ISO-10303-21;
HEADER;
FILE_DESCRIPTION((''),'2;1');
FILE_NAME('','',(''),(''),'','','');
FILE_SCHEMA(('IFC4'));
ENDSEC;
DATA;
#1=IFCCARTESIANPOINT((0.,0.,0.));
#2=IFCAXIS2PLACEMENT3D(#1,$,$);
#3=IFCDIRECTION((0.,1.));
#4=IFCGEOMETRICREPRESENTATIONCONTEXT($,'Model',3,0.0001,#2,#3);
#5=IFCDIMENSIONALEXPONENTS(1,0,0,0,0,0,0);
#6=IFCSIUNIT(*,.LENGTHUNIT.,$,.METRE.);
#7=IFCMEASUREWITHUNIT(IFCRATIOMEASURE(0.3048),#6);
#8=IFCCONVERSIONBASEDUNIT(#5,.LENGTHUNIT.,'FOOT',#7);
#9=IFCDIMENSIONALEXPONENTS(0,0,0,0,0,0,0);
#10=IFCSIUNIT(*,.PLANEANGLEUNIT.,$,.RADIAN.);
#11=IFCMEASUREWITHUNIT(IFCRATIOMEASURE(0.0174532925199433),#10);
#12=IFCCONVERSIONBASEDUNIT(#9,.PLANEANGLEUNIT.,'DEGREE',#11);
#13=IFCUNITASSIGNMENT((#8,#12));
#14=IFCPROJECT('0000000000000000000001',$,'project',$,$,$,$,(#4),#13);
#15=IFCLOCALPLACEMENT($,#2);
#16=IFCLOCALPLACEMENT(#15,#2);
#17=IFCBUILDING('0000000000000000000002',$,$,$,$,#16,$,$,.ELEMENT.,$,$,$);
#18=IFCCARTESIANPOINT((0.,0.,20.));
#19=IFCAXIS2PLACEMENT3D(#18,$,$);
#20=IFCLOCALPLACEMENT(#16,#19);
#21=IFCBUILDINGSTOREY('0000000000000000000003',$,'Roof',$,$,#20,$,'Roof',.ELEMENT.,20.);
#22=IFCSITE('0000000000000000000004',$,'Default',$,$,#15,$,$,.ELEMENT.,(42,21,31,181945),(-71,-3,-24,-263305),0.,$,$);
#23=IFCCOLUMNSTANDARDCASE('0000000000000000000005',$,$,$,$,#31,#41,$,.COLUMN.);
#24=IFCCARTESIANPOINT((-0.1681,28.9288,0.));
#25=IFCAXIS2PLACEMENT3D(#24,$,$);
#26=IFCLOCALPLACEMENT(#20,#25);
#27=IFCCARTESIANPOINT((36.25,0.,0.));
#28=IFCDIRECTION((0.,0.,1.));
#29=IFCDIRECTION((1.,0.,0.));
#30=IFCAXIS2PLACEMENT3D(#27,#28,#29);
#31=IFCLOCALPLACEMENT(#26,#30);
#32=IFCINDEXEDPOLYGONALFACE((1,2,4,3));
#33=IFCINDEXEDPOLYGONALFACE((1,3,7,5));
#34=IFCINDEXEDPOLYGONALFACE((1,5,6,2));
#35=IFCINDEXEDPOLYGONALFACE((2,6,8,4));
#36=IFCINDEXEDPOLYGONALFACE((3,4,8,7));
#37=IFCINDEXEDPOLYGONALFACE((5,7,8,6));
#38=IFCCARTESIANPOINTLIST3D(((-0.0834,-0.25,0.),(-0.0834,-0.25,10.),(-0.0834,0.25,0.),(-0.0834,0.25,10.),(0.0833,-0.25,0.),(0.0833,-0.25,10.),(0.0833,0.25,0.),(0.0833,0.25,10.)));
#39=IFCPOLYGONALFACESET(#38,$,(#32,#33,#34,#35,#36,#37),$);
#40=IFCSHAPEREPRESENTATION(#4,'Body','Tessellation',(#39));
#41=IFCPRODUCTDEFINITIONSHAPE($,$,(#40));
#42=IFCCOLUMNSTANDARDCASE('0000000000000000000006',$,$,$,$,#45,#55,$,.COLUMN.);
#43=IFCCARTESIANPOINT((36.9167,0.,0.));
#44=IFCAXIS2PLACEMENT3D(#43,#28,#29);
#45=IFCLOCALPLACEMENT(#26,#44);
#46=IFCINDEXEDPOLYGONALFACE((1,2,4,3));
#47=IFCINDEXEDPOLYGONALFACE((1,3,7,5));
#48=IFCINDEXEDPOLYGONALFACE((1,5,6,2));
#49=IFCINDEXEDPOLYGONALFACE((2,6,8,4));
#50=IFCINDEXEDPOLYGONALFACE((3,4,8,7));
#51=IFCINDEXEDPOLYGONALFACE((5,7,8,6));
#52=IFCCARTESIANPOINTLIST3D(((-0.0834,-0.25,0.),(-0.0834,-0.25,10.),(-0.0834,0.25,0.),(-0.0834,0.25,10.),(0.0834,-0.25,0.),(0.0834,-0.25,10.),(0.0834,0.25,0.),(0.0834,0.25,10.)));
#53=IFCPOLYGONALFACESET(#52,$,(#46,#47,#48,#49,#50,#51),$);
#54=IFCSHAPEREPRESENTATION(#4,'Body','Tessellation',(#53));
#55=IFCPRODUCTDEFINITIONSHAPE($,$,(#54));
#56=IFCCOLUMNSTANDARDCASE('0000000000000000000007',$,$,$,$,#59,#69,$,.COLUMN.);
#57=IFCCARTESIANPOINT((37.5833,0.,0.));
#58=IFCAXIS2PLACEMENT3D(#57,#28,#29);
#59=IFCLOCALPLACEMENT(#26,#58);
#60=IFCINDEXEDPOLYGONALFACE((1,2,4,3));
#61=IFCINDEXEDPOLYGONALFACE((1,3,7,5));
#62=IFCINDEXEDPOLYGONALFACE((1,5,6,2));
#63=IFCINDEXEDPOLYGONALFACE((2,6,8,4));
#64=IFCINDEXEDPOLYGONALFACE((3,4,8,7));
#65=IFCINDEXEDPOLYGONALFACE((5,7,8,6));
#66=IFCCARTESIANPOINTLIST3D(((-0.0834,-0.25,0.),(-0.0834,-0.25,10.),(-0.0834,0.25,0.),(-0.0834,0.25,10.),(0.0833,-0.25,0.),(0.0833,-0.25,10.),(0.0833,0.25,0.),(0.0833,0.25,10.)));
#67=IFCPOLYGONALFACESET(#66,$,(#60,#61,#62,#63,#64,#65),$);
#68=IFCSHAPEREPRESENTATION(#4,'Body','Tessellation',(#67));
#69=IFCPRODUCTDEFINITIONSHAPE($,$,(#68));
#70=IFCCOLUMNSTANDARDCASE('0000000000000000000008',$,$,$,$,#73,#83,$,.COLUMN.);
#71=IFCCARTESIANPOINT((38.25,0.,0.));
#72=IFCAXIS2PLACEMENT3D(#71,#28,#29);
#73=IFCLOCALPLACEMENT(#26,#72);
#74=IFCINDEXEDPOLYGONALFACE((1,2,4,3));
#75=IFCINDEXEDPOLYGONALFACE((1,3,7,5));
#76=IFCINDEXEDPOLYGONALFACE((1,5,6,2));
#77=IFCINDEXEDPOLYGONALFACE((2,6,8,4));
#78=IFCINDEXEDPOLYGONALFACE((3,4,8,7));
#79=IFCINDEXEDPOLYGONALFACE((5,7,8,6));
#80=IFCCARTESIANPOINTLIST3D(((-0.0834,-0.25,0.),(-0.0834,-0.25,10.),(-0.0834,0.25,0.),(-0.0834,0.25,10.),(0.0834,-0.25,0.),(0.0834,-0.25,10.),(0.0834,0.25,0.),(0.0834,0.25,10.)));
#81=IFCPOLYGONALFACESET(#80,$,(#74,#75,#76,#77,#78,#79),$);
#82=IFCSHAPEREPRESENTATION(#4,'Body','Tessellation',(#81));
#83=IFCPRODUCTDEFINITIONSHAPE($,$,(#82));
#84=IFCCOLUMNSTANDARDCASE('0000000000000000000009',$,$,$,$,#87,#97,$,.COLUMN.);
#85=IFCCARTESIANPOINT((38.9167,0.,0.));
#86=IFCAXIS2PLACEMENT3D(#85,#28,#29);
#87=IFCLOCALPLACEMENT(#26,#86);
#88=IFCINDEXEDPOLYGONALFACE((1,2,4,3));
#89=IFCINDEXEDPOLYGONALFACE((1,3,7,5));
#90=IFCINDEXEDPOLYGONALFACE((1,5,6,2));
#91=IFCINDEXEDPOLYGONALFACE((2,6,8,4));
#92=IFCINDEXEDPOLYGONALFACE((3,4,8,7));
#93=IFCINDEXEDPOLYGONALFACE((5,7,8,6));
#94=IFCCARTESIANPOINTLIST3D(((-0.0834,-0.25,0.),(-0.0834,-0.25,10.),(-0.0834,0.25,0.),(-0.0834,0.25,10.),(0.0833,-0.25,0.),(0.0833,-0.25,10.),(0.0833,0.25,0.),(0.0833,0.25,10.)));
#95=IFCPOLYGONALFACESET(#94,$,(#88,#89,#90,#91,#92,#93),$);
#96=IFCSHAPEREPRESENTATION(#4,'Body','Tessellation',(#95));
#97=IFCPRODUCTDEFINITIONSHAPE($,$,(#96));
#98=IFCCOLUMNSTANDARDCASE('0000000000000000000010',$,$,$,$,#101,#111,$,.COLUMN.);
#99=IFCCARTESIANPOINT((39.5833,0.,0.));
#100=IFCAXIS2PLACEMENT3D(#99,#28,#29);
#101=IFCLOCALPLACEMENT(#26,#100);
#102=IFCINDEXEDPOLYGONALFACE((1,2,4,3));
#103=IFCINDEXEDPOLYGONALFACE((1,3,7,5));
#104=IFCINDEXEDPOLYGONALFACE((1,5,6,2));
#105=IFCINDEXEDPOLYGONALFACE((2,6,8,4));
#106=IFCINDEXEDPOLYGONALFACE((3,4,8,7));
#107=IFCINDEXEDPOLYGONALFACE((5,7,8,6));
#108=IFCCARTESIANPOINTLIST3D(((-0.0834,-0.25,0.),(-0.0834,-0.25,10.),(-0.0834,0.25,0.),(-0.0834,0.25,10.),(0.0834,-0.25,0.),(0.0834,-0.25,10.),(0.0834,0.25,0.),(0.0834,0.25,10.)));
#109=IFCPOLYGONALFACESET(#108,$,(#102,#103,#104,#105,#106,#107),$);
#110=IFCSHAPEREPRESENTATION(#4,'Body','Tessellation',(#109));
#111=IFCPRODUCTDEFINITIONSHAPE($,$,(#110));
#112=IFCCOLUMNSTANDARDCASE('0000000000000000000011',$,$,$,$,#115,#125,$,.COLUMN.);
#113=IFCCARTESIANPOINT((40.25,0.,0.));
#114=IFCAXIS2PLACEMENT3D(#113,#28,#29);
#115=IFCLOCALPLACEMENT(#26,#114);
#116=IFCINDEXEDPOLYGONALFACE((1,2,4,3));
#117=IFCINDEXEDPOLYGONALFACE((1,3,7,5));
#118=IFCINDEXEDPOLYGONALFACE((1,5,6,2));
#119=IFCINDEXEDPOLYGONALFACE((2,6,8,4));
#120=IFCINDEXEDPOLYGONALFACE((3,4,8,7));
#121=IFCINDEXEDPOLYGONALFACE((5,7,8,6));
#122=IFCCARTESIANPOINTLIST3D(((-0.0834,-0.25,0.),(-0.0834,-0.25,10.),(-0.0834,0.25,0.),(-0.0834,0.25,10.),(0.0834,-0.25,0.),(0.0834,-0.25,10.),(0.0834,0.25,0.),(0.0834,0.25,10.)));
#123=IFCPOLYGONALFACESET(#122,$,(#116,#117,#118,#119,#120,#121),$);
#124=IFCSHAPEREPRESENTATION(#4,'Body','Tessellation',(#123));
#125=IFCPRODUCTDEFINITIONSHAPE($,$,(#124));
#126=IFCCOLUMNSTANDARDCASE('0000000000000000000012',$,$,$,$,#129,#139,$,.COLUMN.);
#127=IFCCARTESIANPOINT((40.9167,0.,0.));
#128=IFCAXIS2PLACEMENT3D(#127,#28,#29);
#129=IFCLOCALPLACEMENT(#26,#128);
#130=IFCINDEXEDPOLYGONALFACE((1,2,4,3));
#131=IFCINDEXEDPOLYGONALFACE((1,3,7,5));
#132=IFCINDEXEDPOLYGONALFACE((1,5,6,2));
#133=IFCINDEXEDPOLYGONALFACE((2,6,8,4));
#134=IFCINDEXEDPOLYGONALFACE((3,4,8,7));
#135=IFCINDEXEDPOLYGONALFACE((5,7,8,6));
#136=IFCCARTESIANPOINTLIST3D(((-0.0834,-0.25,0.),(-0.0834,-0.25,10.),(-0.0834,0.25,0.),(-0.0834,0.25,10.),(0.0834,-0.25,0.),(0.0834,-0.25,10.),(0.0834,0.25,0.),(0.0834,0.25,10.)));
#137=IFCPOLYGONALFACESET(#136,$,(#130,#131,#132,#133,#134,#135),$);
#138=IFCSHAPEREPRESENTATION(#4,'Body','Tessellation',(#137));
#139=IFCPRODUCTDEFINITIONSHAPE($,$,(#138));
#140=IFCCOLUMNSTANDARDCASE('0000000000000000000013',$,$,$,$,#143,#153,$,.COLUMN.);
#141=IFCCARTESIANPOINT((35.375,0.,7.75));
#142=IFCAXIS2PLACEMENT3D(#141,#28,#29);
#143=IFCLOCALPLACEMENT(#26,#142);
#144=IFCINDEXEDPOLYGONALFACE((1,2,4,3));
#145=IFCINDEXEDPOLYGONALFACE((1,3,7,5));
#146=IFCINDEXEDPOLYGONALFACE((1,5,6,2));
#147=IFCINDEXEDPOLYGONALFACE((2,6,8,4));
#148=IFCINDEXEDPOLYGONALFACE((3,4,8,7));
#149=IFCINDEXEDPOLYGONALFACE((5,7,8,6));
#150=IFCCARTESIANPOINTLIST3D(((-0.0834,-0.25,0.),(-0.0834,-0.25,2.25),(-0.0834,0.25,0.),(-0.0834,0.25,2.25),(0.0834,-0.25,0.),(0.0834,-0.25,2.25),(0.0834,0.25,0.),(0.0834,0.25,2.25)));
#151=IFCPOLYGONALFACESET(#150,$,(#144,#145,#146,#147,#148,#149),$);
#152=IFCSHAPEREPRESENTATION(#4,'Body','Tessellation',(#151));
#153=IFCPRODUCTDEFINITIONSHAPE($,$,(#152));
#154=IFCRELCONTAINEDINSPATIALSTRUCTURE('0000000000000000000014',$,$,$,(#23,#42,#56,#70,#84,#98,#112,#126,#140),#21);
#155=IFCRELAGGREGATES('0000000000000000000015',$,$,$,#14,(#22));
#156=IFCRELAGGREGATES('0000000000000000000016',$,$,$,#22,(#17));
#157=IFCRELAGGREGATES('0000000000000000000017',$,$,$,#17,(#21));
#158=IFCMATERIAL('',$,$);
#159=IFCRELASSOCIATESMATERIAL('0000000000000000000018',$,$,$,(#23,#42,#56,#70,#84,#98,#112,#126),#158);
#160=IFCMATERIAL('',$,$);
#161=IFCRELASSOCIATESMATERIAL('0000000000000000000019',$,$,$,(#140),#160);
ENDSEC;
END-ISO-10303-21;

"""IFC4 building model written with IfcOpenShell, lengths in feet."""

from ifc_helpers import new_model, entity, si_unit, converted_unit, direction, frame, origin, place, context, project, spatial, rectangle, extrude, material, element, save


model = new_model("IFC4")

# Units and contexts
model_context = context("Model", 3, precision=0.0001, world=origin(), true_north=direction((0.0, 1.0)))
ifc_project = project(units=[converted_unit("LENGTHUNIT", "FOOT", entity("IfcRatioMeasure", 0.3048), si_unit("LENGTHUNIT", "METRE"), dimensions=[1, 0, 0, 0, 0, 0, 0]), converted_unit("PLANEANGLEUNIT", "DEGREE", entity("IfcRatioMeasure", 0.0174532925199433), si_unit("PLANEANGLEUNIT", "RADIAN"), dimensions=[0, 0, 0, 0, 0, 0, 0])], contexts=[model_context])

# Site, building, storey
site_placement = place(None, origin())
site = spatial("IfcSite", under=ifc_project, at=site_placement, Name="Default", CompositionType="ELEMENT", RefLatitude=(42, 21, 31, 181945), RefLongitude=(-71, -3, -24, -263305), RefElevation=0.0)
building_placement = place(site_placement, origin())
building = spatial("IfcBuilding", under=site, at=building_placement, CompositionType="ELEMENT")
storey_placement = place(building_placement, frame((0.0, 0.0, 20.0)))
storey = spatial("IfcBuildingStorey", under=building, at=storey_placement, Name="Roof", LongName="Roof", CompositionType="ELEMENT", Elevation=20.0)

# Columns
ifc_material_1 = material(Name="")
placement = place(storey_placement, frame((-0.1681, 28.9288, 0.0)))
for number, where, z_axis, x_axis in (
    (1, (36.25, 0.0, 0.0), (0.0, 0.0, 1.0), (1.0, 0.0, 0.0)),
    (2, (36.9167, 0.0, 0.0), (0.0, 0.0, 1.0), (1.0, 0.0, 0.0)),
    (3, (37.5833, 0.0, 0.0), (0.0, 0.0, 1.0), (1.0, 0.0, 0.0)),
    (4, (38.25, 0.0, 0.0), (0.0, 0.0, 1.0), (1.0, 0.0, 0.0)),
    (5, (38.9167, 0.0, 0.0), (0.0, 0.0, 1.0), (1.0, 0.0, 0.0)),
    (6, (39.5833, 0.0, 0.0), (0.0, 0.0, 1.0), (1.0, 0.0, 0.0)),
    (7, (40.25, 0.0, 0.0), (0.0, 0.0, 1.0), (1.0, 0.0, 0.0)),
    (8, (40.9167, 0.0, 0.0), (0.0, 0.0, 1.0), (1.0, 0.0, 0.0)),
):
    element("IfcColumnStandardCase", number, at=place(placement, frame(where, z_axis=z_axis, x_axis=x_axis)), inside=storey, material=ifc_material_1, PredefinedType="COLUMN", context=model_context, shape_type="SweptSolid", body=[
        extrude(rectangle(XDim=0.1667, YDim=0.5), origin(), (0.0, 0.0, 1.0), 10.0),
    ])
ifc_material_2 = material(Name="")
for number, where, z_axis, x_axis in (
    (9, (35.375, 0.0, 7.75), (0.0, 0.0, 1.0), (1.0, 0.0, 0.0)),
):
    element("IfcColumnStandardCase", number, at=place(placement, frame(where, z_axis=z_axis, x_axis=x_axis)), inside=storey, material=ifc_material_2, PredefinedType="COLUMN", context=model_context, shape_type="SweptSolid", body=[
        extrude(rectangle(XDim=0.1667, YDim=0.5), origin(), (0.0, 0.0, 1.0), 2.25),
    ])

save(model, "model.ifc")
